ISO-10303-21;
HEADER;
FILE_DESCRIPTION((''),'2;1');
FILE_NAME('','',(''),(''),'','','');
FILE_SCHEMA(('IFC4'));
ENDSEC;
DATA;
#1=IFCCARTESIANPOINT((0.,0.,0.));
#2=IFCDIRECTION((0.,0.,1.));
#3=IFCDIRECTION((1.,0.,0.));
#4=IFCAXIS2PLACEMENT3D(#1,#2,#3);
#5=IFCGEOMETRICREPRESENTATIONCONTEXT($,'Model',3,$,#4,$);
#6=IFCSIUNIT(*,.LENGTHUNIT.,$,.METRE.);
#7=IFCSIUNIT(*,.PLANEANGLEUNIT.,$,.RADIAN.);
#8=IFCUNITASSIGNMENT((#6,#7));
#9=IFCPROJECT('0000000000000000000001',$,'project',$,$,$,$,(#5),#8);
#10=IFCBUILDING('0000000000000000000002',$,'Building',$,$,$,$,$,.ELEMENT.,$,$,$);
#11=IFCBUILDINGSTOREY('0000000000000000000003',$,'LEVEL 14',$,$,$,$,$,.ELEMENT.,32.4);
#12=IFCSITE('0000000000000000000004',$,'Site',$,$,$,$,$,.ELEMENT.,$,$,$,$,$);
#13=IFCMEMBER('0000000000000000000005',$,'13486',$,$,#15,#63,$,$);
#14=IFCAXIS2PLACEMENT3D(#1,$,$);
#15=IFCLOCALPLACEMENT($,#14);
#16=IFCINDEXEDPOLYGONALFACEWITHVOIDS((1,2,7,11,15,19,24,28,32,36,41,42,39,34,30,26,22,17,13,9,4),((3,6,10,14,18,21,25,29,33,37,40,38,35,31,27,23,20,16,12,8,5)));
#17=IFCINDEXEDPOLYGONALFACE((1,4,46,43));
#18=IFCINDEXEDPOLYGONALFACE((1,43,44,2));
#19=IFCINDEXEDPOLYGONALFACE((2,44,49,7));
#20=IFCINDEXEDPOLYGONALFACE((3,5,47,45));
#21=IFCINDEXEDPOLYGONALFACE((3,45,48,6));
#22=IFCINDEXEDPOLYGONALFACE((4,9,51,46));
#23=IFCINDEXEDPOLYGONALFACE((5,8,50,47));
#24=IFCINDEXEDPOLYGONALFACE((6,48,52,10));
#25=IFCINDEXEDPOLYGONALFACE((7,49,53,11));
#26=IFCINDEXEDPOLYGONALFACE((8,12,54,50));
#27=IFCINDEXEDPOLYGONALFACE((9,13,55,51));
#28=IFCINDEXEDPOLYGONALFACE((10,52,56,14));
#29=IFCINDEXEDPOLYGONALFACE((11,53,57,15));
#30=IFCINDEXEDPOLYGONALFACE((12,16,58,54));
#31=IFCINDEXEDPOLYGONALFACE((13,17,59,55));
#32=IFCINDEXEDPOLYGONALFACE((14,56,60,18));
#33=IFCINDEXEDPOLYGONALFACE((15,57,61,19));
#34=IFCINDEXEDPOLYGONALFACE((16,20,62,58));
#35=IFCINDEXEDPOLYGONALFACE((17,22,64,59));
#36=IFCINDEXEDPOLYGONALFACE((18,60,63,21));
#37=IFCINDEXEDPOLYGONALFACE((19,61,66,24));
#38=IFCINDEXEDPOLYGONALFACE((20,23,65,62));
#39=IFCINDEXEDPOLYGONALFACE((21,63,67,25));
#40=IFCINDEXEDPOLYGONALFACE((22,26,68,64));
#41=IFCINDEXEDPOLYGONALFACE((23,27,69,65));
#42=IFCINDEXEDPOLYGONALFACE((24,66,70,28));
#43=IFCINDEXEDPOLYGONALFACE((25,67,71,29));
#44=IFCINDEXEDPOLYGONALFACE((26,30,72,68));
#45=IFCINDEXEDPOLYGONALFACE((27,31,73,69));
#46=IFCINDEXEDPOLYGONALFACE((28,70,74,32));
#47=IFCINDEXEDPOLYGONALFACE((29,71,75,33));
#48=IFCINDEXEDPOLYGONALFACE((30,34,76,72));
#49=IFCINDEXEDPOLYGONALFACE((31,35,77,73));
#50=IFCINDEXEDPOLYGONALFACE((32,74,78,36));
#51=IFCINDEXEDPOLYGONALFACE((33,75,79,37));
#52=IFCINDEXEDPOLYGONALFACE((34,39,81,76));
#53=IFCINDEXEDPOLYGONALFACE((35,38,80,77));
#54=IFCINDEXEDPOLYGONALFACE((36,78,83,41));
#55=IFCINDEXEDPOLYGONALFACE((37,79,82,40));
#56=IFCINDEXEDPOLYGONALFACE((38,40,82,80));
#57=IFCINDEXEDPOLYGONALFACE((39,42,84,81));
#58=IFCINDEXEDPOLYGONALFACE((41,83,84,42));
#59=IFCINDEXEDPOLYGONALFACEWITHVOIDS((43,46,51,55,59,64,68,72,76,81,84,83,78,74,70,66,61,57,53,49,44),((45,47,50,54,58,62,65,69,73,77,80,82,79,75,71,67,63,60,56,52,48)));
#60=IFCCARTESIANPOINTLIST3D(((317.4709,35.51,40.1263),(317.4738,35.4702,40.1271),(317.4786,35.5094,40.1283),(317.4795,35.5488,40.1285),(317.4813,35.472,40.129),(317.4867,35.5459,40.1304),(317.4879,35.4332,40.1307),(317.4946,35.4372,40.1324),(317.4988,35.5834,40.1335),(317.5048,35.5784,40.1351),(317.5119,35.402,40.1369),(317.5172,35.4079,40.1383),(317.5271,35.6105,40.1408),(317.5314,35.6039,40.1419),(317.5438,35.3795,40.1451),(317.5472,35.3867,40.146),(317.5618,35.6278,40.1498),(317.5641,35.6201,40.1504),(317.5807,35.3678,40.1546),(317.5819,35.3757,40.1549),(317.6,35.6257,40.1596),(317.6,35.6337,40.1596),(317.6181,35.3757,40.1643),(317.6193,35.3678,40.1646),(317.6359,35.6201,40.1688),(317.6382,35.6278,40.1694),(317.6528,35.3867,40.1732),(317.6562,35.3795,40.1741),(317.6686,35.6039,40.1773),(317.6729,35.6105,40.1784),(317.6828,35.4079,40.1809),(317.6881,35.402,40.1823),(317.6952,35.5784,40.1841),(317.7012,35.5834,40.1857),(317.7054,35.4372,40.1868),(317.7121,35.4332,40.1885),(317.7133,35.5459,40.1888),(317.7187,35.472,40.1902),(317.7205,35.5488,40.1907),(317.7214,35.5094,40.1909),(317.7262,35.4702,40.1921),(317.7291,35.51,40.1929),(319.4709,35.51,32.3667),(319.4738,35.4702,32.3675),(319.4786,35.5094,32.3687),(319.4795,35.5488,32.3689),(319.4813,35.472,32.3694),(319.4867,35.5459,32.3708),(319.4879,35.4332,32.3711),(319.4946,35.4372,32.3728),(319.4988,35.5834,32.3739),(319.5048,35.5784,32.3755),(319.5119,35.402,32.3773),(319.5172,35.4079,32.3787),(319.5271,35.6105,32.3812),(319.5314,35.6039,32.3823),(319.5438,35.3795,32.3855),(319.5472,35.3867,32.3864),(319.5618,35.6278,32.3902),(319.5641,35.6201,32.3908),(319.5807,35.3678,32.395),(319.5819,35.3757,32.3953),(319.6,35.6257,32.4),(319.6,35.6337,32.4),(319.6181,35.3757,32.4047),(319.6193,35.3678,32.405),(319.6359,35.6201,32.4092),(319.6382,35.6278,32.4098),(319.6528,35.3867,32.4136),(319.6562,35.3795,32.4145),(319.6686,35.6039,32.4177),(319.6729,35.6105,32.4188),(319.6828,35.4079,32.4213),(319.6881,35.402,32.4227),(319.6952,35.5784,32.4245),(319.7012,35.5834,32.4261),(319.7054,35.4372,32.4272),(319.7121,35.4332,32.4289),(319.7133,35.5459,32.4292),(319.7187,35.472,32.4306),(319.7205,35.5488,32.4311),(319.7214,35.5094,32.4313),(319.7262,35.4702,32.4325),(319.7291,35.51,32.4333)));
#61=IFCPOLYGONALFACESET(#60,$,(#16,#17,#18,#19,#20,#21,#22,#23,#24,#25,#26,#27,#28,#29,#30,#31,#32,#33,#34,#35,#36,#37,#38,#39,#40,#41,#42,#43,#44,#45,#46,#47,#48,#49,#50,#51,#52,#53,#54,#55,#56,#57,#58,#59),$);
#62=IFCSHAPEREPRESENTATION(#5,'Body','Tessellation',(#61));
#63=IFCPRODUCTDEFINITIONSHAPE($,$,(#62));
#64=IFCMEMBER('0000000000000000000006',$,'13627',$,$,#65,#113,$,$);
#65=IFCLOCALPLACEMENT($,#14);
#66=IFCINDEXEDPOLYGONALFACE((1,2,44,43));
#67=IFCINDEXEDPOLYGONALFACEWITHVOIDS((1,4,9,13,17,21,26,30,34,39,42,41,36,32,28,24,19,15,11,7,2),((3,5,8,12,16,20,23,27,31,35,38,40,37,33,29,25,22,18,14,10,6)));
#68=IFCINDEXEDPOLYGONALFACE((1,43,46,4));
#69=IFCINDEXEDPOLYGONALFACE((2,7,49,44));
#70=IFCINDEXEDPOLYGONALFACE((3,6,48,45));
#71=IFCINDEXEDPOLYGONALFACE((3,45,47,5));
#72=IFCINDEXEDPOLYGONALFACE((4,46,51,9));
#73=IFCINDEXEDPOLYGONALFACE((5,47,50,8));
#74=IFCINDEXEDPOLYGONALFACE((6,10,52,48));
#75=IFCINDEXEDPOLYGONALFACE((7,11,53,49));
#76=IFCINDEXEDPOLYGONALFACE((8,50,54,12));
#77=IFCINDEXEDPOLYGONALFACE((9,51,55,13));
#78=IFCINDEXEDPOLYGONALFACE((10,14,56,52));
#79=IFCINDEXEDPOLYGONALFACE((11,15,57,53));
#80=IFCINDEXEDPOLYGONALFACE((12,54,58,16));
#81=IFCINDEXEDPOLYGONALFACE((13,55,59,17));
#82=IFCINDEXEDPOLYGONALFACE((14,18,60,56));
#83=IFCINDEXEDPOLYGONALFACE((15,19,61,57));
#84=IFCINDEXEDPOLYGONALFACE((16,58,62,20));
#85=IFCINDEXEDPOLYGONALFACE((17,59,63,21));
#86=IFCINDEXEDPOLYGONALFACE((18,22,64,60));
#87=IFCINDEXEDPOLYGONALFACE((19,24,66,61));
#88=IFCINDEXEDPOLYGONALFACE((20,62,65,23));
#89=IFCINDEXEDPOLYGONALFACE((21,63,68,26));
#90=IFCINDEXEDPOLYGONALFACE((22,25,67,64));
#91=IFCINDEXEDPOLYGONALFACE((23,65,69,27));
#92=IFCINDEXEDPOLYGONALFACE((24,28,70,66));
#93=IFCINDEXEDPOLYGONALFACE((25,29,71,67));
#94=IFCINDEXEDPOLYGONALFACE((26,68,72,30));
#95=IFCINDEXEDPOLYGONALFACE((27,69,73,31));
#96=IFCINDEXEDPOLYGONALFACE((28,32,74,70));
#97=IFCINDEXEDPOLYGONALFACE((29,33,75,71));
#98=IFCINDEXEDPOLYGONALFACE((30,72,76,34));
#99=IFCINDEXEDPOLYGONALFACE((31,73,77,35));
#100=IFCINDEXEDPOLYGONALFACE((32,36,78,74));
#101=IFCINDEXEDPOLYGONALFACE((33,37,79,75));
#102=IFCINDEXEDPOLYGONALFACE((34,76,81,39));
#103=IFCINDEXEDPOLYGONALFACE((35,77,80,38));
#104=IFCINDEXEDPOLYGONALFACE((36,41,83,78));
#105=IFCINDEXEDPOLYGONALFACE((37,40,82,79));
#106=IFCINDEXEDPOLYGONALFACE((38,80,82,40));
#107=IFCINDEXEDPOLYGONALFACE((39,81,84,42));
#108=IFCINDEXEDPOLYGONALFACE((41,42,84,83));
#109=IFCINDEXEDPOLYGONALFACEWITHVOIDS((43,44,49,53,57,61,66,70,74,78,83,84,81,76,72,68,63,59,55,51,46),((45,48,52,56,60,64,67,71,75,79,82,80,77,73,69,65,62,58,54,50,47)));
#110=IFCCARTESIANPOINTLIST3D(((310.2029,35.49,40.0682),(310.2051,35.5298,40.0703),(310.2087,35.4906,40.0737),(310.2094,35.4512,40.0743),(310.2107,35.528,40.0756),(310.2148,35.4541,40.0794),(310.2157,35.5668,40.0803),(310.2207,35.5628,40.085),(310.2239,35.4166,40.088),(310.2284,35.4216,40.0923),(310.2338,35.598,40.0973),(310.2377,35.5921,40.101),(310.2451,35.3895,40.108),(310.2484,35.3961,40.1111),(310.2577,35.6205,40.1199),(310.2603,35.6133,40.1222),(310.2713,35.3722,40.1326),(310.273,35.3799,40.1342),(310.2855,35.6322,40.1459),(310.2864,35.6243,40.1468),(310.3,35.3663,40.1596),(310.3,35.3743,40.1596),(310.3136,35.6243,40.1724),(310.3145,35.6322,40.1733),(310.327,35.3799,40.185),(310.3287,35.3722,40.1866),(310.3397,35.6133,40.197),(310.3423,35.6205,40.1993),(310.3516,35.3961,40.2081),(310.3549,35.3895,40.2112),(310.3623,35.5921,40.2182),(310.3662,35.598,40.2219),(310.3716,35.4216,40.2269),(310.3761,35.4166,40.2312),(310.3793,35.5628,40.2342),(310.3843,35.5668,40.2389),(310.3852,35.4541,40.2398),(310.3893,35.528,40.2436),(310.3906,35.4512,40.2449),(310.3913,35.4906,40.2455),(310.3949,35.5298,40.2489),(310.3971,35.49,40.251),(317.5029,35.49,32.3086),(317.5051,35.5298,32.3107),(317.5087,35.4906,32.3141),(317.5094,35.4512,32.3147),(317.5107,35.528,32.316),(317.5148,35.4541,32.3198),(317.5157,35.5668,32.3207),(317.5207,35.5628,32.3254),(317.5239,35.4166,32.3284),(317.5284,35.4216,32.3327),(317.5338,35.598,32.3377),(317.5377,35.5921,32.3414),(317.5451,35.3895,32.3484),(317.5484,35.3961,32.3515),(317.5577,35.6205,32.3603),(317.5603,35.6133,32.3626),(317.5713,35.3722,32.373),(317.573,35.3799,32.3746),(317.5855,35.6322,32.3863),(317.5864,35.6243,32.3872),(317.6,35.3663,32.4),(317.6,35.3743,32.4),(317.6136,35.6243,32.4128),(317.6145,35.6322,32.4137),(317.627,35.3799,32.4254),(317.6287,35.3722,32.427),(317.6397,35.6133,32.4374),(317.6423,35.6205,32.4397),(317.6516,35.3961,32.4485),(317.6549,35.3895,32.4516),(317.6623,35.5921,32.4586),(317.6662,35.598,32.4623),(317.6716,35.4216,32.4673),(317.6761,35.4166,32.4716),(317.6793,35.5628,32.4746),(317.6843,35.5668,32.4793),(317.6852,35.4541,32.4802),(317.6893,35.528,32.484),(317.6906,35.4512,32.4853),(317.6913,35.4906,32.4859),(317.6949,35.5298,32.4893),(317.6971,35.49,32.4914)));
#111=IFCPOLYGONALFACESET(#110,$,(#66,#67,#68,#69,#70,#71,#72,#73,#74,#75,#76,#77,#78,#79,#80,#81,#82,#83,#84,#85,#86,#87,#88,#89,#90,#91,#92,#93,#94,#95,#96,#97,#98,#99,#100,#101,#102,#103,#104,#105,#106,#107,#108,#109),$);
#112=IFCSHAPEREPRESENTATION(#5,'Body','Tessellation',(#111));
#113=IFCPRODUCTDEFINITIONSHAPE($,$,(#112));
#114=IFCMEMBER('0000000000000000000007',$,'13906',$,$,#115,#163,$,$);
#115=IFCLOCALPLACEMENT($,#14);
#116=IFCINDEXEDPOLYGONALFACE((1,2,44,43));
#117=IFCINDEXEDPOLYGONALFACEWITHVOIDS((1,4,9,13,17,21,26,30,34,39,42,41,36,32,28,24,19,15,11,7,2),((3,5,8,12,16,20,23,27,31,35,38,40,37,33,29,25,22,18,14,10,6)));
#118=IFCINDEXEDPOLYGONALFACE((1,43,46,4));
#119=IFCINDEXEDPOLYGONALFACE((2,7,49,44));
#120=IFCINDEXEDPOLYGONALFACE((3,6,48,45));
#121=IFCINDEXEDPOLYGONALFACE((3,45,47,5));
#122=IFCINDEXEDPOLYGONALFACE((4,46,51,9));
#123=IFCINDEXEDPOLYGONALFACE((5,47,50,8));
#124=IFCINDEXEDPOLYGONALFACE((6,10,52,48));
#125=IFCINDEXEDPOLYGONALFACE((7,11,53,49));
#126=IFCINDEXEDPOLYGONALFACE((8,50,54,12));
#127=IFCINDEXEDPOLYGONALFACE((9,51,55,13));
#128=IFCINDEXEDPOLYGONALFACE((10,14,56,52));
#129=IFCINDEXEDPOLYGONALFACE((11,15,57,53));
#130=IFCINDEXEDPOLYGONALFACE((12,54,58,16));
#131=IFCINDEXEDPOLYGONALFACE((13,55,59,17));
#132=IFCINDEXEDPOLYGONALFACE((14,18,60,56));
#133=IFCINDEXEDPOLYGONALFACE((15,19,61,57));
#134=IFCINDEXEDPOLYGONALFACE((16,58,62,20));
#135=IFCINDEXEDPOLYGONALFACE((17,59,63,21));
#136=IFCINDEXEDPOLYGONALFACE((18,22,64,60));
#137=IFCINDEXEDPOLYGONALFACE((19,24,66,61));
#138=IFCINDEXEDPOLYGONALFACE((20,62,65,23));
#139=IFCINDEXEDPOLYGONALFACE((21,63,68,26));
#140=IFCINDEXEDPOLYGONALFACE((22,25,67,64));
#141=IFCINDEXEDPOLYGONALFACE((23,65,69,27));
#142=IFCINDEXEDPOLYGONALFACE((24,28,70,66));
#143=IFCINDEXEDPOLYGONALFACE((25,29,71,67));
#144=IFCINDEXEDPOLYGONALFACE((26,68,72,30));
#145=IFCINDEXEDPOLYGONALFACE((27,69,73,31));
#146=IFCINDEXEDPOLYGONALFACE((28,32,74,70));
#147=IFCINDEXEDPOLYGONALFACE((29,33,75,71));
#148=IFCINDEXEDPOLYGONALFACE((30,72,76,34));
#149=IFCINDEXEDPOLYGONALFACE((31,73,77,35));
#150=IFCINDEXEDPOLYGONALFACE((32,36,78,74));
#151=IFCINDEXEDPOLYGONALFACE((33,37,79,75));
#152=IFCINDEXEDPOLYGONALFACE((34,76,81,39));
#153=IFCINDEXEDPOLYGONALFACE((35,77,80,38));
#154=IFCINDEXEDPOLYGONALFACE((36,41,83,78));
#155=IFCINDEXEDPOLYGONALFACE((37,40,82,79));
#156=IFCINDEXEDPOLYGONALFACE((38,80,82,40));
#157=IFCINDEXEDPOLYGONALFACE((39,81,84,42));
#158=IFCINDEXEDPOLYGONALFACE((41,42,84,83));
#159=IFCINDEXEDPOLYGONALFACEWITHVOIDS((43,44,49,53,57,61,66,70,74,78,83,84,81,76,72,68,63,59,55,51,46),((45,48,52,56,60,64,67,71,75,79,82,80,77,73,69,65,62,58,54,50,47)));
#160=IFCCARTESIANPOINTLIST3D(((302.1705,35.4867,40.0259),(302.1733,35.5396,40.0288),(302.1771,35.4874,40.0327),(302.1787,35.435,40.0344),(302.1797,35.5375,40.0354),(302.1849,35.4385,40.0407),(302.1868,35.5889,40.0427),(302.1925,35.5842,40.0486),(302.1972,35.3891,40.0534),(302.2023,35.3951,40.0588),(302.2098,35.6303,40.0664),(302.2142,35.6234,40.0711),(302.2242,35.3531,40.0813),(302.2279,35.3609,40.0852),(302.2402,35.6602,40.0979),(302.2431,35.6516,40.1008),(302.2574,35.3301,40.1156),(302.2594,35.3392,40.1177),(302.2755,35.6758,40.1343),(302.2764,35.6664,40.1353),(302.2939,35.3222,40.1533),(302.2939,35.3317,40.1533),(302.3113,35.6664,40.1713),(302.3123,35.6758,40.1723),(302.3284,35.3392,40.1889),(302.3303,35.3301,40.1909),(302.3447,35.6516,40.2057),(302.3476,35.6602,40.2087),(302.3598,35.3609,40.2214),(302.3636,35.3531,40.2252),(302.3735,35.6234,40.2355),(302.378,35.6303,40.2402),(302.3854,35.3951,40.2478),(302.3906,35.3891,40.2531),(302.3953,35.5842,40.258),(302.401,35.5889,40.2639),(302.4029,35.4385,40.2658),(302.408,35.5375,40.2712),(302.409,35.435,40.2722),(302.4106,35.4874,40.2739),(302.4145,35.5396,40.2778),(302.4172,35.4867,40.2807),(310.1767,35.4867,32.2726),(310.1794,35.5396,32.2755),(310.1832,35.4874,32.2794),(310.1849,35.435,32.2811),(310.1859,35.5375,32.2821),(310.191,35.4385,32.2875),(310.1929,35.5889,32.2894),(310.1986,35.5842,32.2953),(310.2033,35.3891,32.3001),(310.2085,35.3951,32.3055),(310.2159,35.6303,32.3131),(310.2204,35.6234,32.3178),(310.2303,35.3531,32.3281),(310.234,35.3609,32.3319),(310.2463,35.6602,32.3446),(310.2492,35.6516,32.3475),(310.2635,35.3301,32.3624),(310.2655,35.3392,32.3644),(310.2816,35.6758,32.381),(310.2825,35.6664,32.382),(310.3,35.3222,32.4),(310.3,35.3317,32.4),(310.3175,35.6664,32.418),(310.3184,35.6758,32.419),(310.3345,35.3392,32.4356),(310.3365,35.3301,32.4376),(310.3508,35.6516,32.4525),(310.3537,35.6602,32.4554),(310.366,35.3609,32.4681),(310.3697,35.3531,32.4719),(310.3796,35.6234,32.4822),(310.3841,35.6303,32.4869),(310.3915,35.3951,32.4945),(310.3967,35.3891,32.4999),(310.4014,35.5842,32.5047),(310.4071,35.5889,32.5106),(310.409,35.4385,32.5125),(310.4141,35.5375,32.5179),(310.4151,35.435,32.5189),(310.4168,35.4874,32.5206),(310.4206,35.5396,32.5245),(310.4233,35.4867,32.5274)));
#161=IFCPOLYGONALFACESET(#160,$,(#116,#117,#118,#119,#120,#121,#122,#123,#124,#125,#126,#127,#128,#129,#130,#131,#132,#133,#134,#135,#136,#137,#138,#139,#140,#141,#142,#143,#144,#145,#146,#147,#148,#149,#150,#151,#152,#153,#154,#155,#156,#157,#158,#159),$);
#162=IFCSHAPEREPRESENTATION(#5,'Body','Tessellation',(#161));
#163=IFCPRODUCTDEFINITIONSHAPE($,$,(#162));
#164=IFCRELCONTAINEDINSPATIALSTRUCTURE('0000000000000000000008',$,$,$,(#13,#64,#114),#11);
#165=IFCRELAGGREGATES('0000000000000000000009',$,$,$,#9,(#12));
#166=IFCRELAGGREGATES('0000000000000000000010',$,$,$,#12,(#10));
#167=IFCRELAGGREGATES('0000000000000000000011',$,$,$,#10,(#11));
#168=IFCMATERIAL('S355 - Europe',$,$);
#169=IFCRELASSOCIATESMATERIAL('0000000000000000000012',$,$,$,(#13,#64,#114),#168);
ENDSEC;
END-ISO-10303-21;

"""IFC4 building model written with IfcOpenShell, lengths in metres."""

from ifc_helpers import new_model, si_unit, frame, origin_with_axes, origin_2d_with_axis, place, context, project, spatial, hollow_circle, extrude, material, material_profile, profile_set, profile_usage, element, save


model = new_model("IFC4")

# Units and contexts
model_context = context("Model", 3, world=origin_with_axes())
ifc_project = project(units=[si_unit("LENGTHUNIT", "METRE"), si_unit("PLANEANGLEUNIT", "RADIAN")], contexts=[model_context])

# Site, building, storey
site = spatial("IfcSite", under=ifc_project, Name="Site", CompositionType="ELEMENT")
building = spatial("IfcBuilding", under=site, Name="Building", CompositionType="ELEMENT")
storey = spatial("IfcBuildingStorey", under=building, Name="LEVEL 14", CompositionType="ELEMENT", Elevation=32.4)

# Shared definitions
ifc_material = material(Name="S355 - Europe")

# Members
ifc_material_profile_1 = material_profile(ifc_material, hollow_circle(Radius=0.1337, WallThickness=0.008, at=origin_2d_with_axis()))
ifc_profile_set_1 = profile_set([ifc_material_profile_1])
ifc_profile_usage_1 = profile_usage(ifc_profile_set_1, cardinal=10)
member_1_placement = place(None, frame((317.6, 35.5, 40.1596), z_axis=(0.249588, 0.0, -0.968352), x_axis=(0.0, 1.0, 0.0)))
element("IfcMember", 1, at=member_1_placement, inside=storey, material=ifc_profile_usage_1, Name="13486", context=model_context, shape_type="SweptSolid", body=[
    extrude(hollow_circle(Radius=0.1337, WallThickness=0.008, at=origin_2d_with_axis()), origin_with_axes(), (0.0, 0.0, 1.0), 8.0132),
])
ifc_material_profile_2 = material_profile(ifc_material, hollow_circle(Radius=0.1337, WallThickness=0.008, at=origin_2d_with_axis()))
ifc_profile_set_2 = profile_set([ifc_material_profile_2])
ifc_profile_usage_2 = profile_usage(ifc_profile_set_2, cardinal=10)
member_2_placement = place(None, frame((317.6, 35.5, 32.4), z_axis=(-0.685208, 0.0, 0.728348), x_axis=(0.0, -1.0, 0.0)))
element("IfcMember", 2, at=member_2_placement, inside=storey, material=ifc_profile_usage_2, Name="13627", context=model_context, shape_type="SweptSolid", body=[
    extrude(hollow_circle(Radius=0.1337, WallThickness=0.008, at=origin_2d_with_axis()), origin_with_axes(), (0.0, 0.0, 1.0), 10.6537),
])
ifc_material_profile_3 = material_profile(ifc_material, hollow_circle(Radius=0.1778, WallThickness=0.0095, at=origin_2d_with_axis()))
ifc_profile_set_3 = profile_set([ifc_material_profile_3])
ifc_profile_usage_3 = profile_usage(ifc_profile_set_3, cardinal=10)
member_3_placement = place(None, frame((310.3, 35.5, 32.4), z_axis=(-0.718358, 0.0, 0.695673), x_axis=(0.0, -1.0, 0.0)))
element("IfcMember", 3, at=member_3_placement, inside=storey, material=ifc_profile_usage_3, Name="13906", context=model_context, shape_type="SweptSolid", body=[
    extrude(hollow_circle(Radius=0.1778, WallThickness=0.0095, at=origin_2d_with_axis()), origin_with_axes(), (0.0, 0.0, 1.0), 11.145),
])

save(model, "model.ifc")
